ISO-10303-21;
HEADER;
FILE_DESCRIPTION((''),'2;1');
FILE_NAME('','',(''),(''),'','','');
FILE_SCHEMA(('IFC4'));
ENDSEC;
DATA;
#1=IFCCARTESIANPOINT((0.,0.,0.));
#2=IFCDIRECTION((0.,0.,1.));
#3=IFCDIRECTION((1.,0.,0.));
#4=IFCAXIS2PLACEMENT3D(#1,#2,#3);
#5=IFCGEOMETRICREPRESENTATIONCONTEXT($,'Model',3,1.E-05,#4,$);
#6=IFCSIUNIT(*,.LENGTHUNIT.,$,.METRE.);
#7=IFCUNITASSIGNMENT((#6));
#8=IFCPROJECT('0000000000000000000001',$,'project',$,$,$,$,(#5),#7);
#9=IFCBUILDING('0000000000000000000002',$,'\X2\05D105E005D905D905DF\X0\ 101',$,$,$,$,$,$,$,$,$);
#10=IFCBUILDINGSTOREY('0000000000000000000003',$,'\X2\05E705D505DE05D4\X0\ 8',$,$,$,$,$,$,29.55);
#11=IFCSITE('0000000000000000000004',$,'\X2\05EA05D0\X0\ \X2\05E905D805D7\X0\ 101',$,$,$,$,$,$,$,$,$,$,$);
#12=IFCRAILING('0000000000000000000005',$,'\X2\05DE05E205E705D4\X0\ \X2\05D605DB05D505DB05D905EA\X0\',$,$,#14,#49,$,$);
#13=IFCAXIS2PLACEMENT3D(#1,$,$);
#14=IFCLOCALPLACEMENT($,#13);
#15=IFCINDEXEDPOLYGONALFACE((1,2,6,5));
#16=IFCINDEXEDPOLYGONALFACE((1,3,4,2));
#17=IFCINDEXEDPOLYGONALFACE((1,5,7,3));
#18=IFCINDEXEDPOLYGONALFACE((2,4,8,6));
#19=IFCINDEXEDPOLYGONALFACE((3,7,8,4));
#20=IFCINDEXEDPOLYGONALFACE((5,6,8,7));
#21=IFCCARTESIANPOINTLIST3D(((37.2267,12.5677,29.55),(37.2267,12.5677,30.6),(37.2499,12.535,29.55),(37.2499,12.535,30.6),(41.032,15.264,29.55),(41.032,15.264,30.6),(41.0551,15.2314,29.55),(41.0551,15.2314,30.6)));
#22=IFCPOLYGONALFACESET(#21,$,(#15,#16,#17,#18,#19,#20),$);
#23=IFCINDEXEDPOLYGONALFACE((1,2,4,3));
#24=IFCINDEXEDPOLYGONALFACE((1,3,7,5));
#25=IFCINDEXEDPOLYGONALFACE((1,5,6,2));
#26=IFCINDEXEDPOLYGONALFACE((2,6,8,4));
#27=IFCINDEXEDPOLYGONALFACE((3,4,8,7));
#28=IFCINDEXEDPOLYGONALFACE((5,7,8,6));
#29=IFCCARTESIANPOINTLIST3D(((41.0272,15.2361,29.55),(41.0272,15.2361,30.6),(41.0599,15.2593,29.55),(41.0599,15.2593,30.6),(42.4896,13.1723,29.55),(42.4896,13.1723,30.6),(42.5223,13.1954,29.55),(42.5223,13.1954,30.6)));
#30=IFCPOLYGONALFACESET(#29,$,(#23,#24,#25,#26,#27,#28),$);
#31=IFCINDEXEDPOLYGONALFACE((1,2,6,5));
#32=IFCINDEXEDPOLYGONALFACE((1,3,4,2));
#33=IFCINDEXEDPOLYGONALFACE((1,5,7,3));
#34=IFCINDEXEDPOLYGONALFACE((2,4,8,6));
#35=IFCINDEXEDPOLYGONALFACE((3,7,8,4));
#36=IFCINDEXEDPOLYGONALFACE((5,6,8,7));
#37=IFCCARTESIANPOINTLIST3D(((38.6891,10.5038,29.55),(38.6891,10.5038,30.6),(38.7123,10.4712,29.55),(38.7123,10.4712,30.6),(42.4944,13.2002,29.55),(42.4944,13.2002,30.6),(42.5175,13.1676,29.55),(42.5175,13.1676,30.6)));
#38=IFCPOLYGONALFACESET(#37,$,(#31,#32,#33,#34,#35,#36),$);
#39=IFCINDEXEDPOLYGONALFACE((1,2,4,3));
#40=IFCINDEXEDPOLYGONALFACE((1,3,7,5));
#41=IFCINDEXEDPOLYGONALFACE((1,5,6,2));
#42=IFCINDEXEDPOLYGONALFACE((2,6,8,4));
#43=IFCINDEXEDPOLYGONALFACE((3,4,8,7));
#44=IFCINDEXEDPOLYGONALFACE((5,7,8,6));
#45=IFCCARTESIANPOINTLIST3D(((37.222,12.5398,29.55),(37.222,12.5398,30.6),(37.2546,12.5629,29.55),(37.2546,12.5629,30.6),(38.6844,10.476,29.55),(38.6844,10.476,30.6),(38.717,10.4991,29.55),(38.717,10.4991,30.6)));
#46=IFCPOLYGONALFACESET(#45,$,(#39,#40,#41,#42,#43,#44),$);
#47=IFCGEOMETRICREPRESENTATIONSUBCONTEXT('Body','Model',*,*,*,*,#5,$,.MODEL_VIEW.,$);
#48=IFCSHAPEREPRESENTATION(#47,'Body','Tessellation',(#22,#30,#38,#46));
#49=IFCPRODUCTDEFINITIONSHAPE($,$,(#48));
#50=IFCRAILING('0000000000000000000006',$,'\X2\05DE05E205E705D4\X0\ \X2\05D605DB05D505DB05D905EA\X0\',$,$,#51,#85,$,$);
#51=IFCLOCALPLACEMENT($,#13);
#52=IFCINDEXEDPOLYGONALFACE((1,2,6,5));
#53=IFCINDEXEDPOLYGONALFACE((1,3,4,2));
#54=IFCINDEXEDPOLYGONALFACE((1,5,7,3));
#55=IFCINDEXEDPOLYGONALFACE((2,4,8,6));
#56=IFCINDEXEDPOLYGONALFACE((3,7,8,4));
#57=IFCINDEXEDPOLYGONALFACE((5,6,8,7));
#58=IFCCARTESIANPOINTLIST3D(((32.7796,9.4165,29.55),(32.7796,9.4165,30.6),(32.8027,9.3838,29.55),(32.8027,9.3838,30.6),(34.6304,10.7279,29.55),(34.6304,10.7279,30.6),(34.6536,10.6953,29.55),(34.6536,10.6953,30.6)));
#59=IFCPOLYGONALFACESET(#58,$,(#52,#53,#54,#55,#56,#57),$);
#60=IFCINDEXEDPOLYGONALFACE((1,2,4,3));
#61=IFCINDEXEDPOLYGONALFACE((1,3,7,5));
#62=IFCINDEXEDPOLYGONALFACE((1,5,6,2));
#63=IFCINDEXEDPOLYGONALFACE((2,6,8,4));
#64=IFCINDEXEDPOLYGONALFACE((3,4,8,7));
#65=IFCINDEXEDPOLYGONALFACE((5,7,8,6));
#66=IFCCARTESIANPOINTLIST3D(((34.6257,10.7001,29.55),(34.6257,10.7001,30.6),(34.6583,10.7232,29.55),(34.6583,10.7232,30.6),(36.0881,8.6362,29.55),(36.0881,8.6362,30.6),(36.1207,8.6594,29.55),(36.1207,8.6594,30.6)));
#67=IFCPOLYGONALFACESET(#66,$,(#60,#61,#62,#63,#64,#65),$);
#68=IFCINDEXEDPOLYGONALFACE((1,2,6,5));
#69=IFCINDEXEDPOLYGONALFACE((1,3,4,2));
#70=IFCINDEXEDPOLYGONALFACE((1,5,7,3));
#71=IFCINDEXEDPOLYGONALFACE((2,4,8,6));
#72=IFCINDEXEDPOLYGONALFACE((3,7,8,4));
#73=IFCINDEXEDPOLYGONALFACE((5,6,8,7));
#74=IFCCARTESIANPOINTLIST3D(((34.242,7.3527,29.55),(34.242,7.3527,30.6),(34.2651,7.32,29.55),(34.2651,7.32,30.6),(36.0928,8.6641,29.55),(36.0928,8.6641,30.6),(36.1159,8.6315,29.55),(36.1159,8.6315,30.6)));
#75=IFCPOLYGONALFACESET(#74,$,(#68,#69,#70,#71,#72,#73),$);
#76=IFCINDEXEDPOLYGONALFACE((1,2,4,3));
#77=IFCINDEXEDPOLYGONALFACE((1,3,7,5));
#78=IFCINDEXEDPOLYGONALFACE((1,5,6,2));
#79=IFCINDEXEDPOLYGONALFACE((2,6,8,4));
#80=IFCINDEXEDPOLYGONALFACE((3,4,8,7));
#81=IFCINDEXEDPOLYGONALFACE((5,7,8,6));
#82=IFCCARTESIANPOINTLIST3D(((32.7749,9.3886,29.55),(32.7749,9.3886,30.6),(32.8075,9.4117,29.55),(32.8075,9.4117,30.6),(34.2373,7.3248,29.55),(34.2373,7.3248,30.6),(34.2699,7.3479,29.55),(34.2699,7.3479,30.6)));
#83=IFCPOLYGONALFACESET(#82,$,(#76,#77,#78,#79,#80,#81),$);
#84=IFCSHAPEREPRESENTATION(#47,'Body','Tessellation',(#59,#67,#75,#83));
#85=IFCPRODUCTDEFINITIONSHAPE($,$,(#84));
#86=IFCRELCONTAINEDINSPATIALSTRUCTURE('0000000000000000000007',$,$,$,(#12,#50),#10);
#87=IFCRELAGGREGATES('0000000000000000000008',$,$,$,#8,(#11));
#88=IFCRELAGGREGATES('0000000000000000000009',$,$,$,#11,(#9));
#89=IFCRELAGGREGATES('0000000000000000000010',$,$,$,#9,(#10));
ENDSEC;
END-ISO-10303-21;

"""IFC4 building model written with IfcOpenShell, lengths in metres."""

from ifc_helpers import new_model, si_unit, frame, origin_with_axes, context, subcontext, project, spatial, polyline, outline, extrude, element, save


model = new_model("IFC4")

# Units and contexts
model_context = context("Model", 3, precision=1e-05, world=origin_with_axes())
body_context = subcontext(model_context, "Body", "Model", "MODEL_VIEW")
ifc_project = project(units=[si_unit("LENGTHUNIT", "METRE")], contexts=[model_context])

# Site, building, storey
site = spatial("IfcSite", under=ifc_project, Name="תא שטח 101")
building = spatial("IfcBuilding", under=site, Name="בניין 101")
storey = spatial("IfcBuildingStorey", under=building, Name="קומה 8", Elevation=29.55)

# Railings
element("IfcRailing", 1, inside=storey, Name="מעקה זכוכית", context=body_context, shape_type="SweptSolid", body=[
    extrude(outline(polyline([(37.2499, 12.535), (41.0551, 15.2314), (41.032, 15.264), (37.2267, 12.5677), (37.2499, 12.535)])), frame((0.0, 0.0, 29.55)), (0.0, 0.0, 1.0), 1.05),
    extrude(outline(polyline([(41.0272, 15.2361), (42.4896, 13.1723), (42.5223, 13.1954), (41.0599, 15.2593), (41.0272, 15.2361)])), frame((0.0, 0.0, 29.55)), (0.0, 0.0, 1.0), 1.05),
    extrude(outline(polyline([(42.4944, 13.2002), (38.6891, 10.5038), (38.7123, 10.4712), (42.5175, 13.1676), (42.4944, 13.2002)])), frame((0.0, 0.0, 29.55)), (0.0, 0.0, 1.0), 1.05),
    extrude(outline(polyline([(38.717, 10.4991), (37.2546, 12.5629), (37.222, 12.5398), (38.6844, 10.476), (38.717, 10.4991)])), frame((0.0, 0.0, 29.55)), (0.0, 0.0, 1.0), 1.05),
])
element("IfcRailing", 2, inside=storey, Name="מעקה זכוכית", context=body_context, shape_type="SweptSolid", body=[
    extrude(outline(polyline([(32.8027, 9.3838), (34.6536, 10.6953), (34.6304, 10.7279), (32.7796, 9.4165), (32.8027, 9.3838)])), frame((0.0, 0.0, 29.55)), (0.0, 0.0, 1.0), 1.05),
    extrude(outline(polyline([(34.6257, 10.7001), (36.0881, 8.6362), (36.1207, 8.6594), (34.6583, 10.7232), (34.6257, 10.7001)])), frame((0.0, 0.0, 29.55)), (0.0, 0.0, 1.0), 1.05),
    extrude(outline(polyline([(36.0928, 8.6641), (34.242, 7.3527), (34.2651, 7.32), (36.1159, 8.6315), (36.0928, 8.6641)])), frame((0.0, 0.0, 29.55)), (0.0, 0.0, 1.0), 1.05),
    extrude(outline(polyline([(34.2699, 7.3479), (32.8075, 9.4117), (32.7749, 9.3886), (34.2373, 7.3248), (34.2699, 7.3479)])), frame((0.0, 0.0, 29.55)), (0.0, 0.0, 1.0), 1.05),
])

save(model, "model.ifc")
